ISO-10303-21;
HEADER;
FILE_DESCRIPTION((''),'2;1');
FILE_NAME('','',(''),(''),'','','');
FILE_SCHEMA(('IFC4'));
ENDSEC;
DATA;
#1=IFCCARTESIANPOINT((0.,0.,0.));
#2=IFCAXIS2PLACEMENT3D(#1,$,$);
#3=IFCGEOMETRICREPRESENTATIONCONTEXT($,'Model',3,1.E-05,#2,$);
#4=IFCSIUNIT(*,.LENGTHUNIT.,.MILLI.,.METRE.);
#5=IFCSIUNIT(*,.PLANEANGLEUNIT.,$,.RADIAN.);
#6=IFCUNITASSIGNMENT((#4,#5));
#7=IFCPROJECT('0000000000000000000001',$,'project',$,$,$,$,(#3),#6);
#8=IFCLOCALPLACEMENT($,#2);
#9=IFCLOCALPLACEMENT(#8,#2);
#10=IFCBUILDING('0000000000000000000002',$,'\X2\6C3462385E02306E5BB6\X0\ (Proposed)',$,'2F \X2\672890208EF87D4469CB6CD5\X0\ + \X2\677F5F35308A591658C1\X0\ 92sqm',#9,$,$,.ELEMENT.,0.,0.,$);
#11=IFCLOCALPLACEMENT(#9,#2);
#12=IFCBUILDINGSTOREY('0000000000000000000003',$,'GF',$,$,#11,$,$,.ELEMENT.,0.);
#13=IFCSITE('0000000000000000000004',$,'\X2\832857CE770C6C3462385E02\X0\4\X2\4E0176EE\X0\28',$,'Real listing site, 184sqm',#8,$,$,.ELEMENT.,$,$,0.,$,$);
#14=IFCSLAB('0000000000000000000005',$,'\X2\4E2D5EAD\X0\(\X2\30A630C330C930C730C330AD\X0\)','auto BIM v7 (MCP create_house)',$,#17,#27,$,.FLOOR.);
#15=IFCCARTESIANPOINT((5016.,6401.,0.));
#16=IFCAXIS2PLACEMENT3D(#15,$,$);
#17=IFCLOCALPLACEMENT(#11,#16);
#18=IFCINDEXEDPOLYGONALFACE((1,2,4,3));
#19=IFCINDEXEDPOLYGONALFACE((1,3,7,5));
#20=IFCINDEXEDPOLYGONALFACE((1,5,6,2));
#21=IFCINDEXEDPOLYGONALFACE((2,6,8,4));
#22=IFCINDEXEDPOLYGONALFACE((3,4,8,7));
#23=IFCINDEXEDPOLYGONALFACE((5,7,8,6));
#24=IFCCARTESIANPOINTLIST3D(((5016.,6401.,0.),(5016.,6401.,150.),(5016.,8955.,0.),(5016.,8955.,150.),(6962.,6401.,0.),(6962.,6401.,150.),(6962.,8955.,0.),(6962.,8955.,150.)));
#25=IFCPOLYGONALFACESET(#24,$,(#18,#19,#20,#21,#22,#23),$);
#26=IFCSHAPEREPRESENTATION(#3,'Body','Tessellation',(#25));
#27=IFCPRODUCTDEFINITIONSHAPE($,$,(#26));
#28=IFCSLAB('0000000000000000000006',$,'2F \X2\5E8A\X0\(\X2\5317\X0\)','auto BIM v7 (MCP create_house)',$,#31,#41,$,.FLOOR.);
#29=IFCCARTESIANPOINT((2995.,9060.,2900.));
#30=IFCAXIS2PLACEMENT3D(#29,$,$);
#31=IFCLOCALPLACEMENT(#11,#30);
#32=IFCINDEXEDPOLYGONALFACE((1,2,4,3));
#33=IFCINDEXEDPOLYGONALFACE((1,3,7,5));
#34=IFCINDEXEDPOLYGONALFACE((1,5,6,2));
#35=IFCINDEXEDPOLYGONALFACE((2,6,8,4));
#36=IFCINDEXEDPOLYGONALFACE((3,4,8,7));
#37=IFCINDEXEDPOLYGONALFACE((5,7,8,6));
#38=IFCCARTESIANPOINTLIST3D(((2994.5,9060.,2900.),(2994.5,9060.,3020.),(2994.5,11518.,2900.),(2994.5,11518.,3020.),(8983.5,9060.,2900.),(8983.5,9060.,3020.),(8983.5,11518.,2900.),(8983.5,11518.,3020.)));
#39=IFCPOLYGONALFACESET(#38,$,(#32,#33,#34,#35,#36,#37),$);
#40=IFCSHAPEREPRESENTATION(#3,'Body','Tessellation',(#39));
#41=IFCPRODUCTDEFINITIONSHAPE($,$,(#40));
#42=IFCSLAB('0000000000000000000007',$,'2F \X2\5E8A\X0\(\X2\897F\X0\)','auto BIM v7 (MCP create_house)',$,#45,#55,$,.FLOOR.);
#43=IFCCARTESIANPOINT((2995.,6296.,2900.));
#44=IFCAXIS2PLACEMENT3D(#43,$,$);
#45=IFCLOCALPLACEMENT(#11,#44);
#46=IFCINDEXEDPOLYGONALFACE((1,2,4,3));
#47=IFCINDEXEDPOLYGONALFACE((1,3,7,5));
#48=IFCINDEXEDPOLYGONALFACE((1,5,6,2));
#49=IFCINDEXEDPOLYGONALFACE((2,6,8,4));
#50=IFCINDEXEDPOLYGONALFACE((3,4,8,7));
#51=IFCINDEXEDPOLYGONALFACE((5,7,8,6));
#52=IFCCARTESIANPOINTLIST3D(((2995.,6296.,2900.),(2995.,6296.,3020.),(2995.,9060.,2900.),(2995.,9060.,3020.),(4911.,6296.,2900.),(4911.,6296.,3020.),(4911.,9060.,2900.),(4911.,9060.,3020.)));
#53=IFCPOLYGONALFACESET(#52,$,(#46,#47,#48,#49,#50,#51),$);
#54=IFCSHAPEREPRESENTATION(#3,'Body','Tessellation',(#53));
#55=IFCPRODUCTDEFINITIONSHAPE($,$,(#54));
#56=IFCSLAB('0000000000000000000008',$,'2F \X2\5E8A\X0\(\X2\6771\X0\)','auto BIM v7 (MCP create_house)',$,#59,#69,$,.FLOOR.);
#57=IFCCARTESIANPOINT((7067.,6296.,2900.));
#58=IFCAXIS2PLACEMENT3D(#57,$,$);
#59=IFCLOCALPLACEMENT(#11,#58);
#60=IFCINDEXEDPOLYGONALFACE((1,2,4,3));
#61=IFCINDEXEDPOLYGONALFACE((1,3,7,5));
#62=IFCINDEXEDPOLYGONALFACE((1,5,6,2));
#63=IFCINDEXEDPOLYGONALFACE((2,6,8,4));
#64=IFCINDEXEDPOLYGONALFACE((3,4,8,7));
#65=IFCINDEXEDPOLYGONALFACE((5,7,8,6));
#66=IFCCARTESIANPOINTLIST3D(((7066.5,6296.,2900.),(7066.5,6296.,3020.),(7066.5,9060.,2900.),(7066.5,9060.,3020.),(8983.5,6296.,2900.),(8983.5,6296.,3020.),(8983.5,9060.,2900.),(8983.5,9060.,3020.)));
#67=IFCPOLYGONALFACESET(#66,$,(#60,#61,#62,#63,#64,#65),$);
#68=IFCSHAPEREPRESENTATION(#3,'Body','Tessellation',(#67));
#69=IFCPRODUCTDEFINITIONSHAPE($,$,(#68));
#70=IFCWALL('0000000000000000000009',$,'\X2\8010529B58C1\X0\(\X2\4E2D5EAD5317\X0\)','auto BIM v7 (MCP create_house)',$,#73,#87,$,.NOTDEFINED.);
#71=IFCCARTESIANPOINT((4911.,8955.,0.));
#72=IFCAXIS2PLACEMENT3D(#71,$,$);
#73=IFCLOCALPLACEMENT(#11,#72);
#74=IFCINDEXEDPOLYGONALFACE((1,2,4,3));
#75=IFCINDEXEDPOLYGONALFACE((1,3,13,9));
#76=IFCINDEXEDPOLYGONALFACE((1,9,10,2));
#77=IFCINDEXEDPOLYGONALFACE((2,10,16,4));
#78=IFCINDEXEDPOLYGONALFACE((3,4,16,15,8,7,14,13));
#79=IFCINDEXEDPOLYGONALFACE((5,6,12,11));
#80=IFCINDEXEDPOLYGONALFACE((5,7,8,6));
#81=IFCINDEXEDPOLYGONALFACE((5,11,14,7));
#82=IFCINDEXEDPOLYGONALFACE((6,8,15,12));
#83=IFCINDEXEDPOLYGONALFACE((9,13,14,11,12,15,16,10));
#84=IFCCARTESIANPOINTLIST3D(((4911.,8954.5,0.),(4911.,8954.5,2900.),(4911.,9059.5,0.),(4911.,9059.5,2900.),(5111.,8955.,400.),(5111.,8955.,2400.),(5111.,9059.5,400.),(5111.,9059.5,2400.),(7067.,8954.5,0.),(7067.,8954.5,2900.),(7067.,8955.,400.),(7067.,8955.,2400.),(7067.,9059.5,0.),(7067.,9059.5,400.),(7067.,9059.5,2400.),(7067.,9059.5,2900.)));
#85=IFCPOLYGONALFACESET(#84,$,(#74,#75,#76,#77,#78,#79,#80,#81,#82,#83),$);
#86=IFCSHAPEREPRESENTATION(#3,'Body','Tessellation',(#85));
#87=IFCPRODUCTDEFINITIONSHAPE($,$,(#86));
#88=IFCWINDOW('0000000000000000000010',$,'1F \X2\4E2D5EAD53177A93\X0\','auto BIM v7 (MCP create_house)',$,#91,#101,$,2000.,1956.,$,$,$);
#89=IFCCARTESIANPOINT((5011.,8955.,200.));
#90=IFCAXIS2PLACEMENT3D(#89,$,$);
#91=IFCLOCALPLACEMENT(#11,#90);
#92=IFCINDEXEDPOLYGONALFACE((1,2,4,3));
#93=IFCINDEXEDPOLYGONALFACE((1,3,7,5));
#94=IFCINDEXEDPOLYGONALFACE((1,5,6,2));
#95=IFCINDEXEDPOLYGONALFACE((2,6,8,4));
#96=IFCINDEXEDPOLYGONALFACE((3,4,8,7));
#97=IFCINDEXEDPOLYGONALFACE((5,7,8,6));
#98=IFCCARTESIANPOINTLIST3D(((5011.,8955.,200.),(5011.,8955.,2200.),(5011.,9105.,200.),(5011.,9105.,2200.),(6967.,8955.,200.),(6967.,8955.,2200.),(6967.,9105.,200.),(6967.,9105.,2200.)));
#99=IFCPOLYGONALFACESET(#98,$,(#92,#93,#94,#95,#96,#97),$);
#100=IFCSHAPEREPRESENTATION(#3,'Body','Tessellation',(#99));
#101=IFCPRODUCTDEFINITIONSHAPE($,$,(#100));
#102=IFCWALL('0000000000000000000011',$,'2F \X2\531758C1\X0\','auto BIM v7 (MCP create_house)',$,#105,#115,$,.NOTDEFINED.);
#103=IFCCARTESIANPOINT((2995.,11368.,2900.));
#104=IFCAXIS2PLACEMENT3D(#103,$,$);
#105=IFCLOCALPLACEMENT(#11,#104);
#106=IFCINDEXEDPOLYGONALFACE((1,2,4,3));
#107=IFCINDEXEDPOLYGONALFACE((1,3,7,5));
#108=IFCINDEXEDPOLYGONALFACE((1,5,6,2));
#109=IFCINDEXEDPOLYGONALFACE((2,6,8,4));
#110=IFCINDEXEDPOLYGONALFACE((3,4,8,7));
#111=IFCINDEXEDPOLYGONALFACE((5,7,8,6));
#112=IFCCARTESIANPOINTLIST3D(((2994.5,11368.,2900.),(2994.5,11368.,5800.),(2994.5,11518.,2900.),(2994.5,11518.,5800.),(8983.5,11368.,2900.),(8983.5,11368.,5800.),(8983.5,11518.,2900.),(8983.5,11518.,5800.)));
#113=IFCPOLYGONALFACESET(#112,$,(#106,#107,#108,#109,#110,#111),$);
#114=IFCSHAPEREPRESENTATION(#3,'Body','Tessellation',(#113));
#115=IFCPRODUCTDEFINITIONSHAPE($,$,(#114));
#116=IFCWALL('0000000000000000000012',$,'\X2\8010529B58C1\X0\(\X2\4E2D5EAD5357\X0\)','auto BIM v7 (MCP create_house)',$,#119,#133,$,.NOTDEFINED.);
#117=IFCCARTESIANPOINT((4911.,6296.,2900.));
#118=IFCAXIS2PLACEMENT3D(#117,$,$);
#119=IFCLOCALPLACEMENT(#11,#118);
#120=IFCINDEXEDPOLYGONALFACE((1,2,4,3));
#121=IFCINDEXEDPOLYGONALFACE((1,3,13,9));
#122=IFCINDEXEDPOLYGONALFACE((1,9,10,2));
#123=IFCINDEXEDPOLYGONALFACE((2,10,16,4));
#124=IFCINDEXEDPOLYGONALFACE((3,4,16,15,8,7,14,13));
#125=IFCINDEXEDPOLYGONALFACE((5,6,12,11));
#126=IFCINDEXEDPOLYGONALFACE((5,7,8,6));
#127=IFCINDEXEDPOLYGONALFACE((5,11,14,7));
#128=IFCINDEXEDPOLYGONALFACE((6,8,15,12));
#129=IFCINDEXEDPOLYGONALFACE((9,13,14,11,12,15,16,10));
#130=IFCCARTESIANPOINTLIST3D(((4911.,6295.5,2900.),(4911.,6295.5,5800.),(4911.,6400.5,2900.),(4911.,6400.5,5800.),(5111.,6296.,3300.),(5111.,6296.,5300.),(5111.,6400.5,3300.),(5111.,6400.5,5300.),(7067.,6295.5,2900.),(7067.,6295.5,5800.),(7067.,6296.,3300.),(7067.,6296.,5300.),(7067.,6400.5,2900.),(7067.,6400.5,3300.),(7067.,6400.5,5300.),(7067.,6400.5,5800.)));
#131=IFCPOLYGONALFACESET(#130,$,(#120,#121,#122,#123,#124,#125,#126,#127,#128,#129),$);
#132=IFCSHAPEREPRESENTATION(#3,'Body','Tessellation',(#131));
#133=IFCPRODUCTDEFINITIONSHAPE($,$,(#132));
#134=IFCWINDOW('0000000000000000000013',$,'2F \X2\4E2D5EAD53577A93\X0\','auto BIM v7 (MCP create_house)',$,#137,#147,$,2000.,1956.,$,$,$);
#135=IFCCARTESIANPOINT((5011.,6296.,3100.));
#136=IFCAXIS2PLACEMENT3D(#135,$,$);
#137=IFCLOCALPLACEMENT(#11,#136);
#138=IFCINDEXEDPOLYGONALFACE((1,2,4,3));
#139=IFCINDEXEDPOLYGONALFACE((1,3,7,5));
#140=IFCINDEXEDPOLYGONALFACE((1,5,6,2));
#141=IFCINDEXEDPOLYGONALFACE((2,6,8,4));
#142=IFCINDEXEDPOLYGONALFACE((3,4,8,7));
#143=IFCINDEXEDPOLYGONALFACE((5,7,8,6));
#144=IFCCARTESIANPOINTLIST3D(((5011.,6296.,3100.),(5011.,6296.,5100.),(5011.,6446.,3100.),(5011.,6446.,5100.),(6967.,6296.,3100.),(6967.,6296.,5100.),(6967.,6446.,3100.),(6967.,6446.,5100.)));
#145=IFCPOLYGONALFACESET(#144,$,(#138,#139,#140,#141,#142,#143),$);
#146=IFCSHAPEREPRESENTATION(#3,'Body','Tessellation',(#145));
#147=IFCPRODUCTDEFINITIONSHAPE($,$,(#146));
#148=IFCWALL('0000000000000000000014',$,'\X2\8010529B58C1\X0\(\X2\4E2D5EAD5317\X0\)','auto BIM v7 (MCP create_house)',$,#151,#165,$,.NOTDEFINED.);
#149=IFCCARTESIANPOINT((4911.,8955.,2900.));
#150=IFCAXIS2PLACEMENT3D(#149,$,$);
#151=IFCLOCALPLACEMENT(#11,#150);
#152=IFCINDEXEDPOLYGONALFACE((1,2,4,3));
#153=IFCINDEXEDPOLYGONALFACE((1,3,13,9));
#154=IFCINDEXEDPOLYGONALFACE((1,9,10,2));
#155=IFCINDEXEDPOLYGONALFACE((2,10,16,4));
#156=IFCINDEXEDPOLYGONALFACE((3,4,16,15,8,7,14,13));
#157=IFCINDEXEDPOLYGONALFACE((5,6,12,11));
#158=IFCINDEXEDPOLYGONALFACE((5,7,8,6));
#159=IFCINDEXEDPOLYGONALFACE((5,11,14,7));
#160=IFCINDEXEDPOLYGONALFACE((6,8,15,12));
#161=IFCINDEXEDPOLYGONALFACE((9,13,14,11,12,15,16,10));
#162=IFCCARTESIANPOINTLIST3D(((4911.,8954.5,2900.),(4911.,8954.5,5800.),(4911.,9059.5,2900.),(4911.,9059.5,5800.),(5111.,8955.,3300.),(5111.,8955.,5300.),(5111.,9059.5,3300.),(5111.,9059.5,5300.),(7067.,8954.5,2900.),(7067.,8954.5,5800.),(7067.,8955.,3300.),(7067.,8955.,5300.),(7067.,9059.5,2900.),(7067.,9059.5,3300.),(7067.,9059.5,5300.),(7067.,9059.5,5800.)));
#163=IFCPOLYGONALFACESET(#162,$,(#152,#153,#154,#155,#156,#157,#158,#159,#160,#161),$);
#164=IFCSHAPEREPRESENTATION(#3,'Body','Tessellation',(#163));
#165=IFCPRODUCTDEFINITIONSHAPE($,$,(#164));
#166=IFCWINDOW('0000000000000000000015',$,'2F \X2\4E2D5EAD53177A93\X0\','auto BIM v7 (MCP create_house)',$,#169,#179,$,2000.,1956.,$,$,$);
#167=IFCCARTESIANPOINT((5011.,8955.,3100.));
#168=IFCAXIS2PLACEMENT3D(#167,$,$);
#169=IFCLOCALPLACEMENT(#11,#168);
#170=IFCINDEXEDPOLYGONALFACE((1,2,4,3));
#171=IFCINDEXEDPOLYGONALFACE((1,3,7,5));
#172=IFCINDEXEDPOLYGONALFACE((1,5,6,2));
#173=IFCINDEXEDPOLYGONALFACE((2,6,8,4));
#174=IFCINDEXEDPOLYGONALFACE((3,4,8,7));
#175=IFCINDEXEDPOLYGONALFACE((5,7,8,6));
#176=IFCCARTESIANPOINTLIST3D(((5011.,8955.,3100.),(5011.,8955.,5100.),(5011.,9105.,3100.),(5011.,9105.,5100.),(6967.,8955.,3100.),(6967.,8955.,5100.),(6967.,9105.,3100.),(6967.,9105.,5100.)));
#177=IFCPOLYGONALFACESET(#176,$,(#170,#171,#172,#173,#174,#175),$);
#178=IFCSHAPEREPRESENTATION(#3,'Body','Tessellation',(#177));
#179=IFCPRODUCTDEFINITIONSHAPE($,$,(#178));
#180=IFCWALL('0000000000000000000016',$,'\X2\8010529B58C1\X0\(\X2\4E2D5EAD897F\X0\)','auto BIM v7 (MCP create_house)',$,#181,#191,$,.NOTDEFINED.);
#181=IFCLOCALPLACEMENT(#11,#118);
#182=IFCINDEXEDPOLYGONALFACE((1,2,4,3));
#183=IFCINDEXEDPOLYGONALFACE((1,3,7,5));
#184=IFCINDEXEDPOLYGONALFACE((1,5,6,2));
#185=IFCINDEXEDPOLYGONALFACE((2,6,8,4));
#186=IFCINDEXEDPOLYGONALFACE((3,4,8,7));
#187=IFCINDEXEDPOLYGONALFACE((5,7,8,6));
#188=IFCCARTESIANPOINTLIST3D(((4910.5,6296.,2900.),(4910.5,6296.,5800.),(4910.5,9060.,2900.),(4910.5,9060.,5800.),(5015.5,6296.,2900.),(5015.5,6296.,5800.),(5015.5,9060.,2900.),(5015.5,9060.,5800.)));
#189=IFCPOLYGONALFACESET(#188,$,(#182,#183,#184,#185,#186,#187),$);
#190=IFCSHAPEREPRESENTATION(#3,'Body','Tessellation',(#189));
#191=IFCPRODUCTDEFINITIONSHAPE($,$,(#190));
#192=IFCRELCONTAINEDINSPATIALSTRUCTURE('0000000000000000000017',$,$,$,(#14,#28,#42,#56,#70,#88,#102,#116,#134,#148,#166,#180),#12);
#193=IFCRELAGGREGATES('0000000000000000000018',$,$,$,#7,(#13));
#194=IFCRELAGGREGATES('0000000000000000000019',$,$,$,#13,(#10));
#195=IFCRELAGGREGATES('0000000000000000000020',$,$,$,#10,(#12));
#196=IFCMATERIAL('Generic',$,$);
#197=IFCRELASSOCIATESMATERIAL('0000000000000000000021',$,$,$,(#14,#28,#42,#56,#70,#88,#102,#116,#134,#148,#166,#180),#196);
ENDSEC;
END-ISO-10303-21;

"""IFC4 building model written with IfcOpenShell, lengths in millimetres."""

from ifc_helpers import new_model, si_unit, frame, frame_2d, origin, place, context, project, spatial, rectangle, extrude, material, element, fill, save


model = new_model("IFC4")

# Units and contexts
model_context = context("Model", 3, precision=1e-05, world=origin())
ifc_project = project(units=[si_unit("LENGTHUNIT", "METRE", prefix="MILLI"), si_unit("PLANEANGLEUNIT", "RADIAN")], contexts=[model_context])

# Site, building, storey
site_placement = place(None, origin())
site = spatial("IfcSite", under=ifc_project, at=site_placement, Name="茨城県水戸市4丁目28", ObjectType="Real listing site, 184sqm", CompositionType="ELEMENT", RefElevation=0.0)
building_placement = place(site_placement, origin())
building = spatial("IfcBuilding", under=site, at=building_placement, Name="水戸市の家 (Proposed)", ObjectType="2F 木造軸組構法 + 板張り外壁 92sqm", CompositionType="ELEMENT", ElevationOfRefHeight=0.0, ElevationOfTerrain=0.0)
storey_placement = place(building_placement, origin())
storey = spatial("IfcBuildingStorey", under=building, at=storey_placement, Name="GF", CompositionType="ELEMENT", Elevation=0.0)

# Slabs
ifc_material = material(Name="Generic")
slab_1_placement = place(storey_placement, frame((5016.0, 6401.0, 0.0)))
element("IfcSlab", 1, at=slab_1_placement, inside=storey, material=ifc_material, Name="中庭(ウッドデッキ)", Description="auto BIM v7 (MCP create_house)", PredefinedType="FLOOR", context=model_context, shape_type="SweptSolid", body=[
    extrude(rectangle(XDim=1946.0, YDim=2554.0, at=frame_2d((973.0, 1277.0))), frame((5016.0, 6401.0, 0.0)), (0.0, 0.0, 1.0), 150.0),
])
slab_2_placement = place(storey_placement, frame((2995.0, 9060.0, 2900.0)))
element("IfcSlab", 2, at=slab_2_placement, inside=storey, material=ifc_material, Name="2F 床(北)", Description="auto BIM v7 (MCP create_house)", PredefinedType="FLOOR", context=model_context, shape_type="SweptSolid", body=[
    extrude(rectangle(XDim=5989.0, YDim=2458.0, at=frame_2d((2994.0, 1229.0))), frame((2995.0, 9060.0, 2900.0)), (0.0, 0.0, 1.0), 120.0),
])
slab_3_placement = place(storey_placement, frame((2995.0, 6296.0, 2900.0)))
element("IfcSlab", 3, at=slab_3_placement, inside=storey, material=ifc_material, Name="2F 床(西)", Description="auto BIM v7 (MCP create_house)", PredefinedType="FLOOR", context=model_context, shape_type="SweptSolid", body=[
    extrude(rectangle(XDim=1916.0, YDim=2764.0, at=frame_2d((958.0, 1382.0))), frame((2995.0, 6296.0, 2900.0)), (0.0, 0.0, 1.0), 120.0),
])
slab_4_placement = place(storey_placement, frame((7067.0, 6296.0, 2900.0)))
element("IfcSlab", 4, at=slab_4_placement, inside=storey, material=ifc_material, Name="2F 床(東)", Description="auto BIM v7 (MCP create_house)", PredefinedType="FLOOR", context=model_context, shape_type="SweptSolid", body=[
    extrude(rectangle(XDim=1917.0, YDim=2764.0, at=frame_2d((958.0, 1382.0))), frame((7067.0, 6296.0, 2900.0)), (0.0, 0.0, 1.0), 120.0),
])

# Wall, opening, window
wall_1_placement = place(storey_placement, frame((4911.0, 8955.0, 0.0)))
wall_1 = element("IfcWall", 5, at=wall_1_placement, inside=storey, material=ifc_material, Name="耐力壁(中庭北)", Description="auto BIM v7 (MCP create_house)", PredefinedType="NOTDEFINED", context=model_context, shape_type="SweptSolid", body=[
    extrude(rectangle(XDim=2156.0, YDim=105.0, at=frame_2d((1078.0, 52.0))), frame((4911.0, 8955.0, 0.0)), (0.0, 0.0, 1.0), 2900.0),
])
opening_1_placement = place(storey_placement, frame((5011.0, 8955.0, 200.0)))
opening_1 = element("IfcOpeningElement", 6, at=opening_1_placement, cuts=wall_1, PredefinedType="NOTDEFINED", context=model_context, shape_type="SweptSolid", body=[
    extrude(rectangle(XDim=1956.0, YDim=150.0, at=frame_2d((978.0, 75.0))), frame((5011.0, 8955.0, 200.0)), (0.0, 0.0, 1.0), 2000.0),
])
window_1_placement = place(storey_placement, frame((5011.0, 8955.0, 200.0)))
window_1 = element("IfcWindow", 7, at=window_1_placement, inside=storey, material=ifc_material, Name="1F 中庭北窓", Description="auto BIM v7 (MCP create_house)", OverallHeight=2000.0, OverallWidth=1956.0, context=model_context, shape_type="SweptSolid", body=[
    extrude(rectangle(XDim=1956.0, YDim=150.0, at=frame_2d((978.0, 75.0))), frame((5011.0, 8955.0, 200.0)), (0.0, 0.0, 1.0), 2000.0),
])
fill(opening_1, window_1)

# Wall
wall_2_placement = place(storey_placement, frame((2995.0, 11368.0, 2900.0)))
element("IfcWall", 8, at=wall_2_placement, inside=storey, material=ifc_material, Name="2F 北壁", Description="auto BIM v7 (MCP create_house)", PredefinedType="NOTDEFINED", context=model_context, shape_type="SweptSolid", body=[
    extrude(rectangle(XDim=5989.0, YDim=150.0, at=frame_2d((2994.0, 75.0))), frame((2995.0, 11368.0, 2900.0)), (0.0, 0.0, 1.0), 2900.0),
])

# Walls, openings, windows
wall_3_placement = place(storey_placement, frame((4911.0, 6296.0, 2900.0)))
wall_3 = element("IfcWall", 9, at=wall_3_placement, inside=storey, material=ifc_material, Name="耐力壁(中庭南)", Description="auto BIM v7 (MCP create_house)", PredefinedType="NOTDEFINED", context=model_context, shape_type="SweptSolid", body=[
    extrude(rectangle(XDim=2156.0, YDim=105.0, at=frame_2d((1078.0, 52.0))), frame((4911.0, 6296.0, 2900.0)), (0.0, 0.0, 1.0), 2900.0),
])
opening_2_placement = place(storey_placement, frame((5011.0, 6296.0, 3100.0)))
opening_2 = element("IfcOpeningElement", 10, at=opening_2_placement, cuts=wall_3, PredefinedType="NOTDEFINED", context=model_context, shape_type="SweptSolid", body=[
    extrude(rectangle(XDim=1956.0, YDim=150.0, at=frame_2d((978.0, 75.0))), frame((5011.0, 6296.0, 3100.0)), (0.0, 0.0, 1.0), 2000.0),
])
window_2_placement = place(storey_placement, frame((5011.0, 6296.0, 3100.0)))
window_2 = element("IfcWindow", 11, at=window_2_placement, inside=storey, material=ifc_material, Name="2F 中庭南窓", Description="auto BIM v7 (MCP create_house)", OverallHeight=2000.0, OverallWidth=1956.0, context=model_context, shape_type="SweptSolid", body=[
    extrude(rectangle(XDim=1956.0, YDim=150.0, at=frame_2d((978.0, 75.0))), frame((5011.0, 6296.0, 3100.0)), (0.0, 0.0, 1.0), 2000.0),
])
fill(opening_2, window_2)
wall_4_placement = place(storey_placement, frame((4911.0, 8955.0, 2900.0)))
wall_4 = element("IfcWall", 12, at=wall_4_placement, inside=storey, material=ifc_material, Name="耐力壁(中庭北)", Description="auto BIM v7 (MCP create_house)", PredefinedType="NOTDEFINED", context=model_context, shape_type="SweptSolid", body=[
    extrude(rectangle(XDim=2156.0, YDim=105.0, at=frame_2d((1078.0, 52.0))), frame((4911.0, 8955.0, 2900.0)), (0.0, 0.0, 1.0), 2900.0),
])
opening_3_placement = place(storey_placement, frame((5011.0, 8955.0, 3100.0)))
opening_3 = element("IfcOpeningElement", 13, at=opening_3_placement, cuts=wall_4, PredefinedType="NOTDEFINED", context=model_context, shape_type="SweptSolid", body=[
    extrude(rectangle(XDim=1956.0, YDim=150.0, at=frame_2d((978.0, 75.0))), frame((5011.0, 8955.0, 3100.0)), (0.0, 0.0, 1.0), 2000.0),
])
window_3_placement = place(storey_placement, frame((5011.0, 8955.0, 3100.0)))
window_3 = element("IfcWindow", 14, at=window_3_placement, inside=storey, material=ifc_material, Name="2F 中庭北窓", Description="auto BIM v7 (MCP create_house)", OverallHeight=2000.0, OverallWidth=1956.0, context=model_context, shape_type="SweptSolid", body=[
    extrude(rectangle(XDim=1956.0, YDim=150.0, at=frame_2d((978.0, 75.0))), frame((5011.0, 8955.0, 3100.0)), (0.0, 0.0, 1.0), 2000.0),
])
fill(opening_3, window_3)

# Wall
wall_5_placement = place(storey_placement, frame((4911.0, 6296.0, 2900.0)))
element("IfcWall", 15, at=wall_5_placement, inside=storey, material=ifc_material, Name="耐力壁(中庭西)", Description="auto BIM v7 (MCP create_house)", PredefinedType="NOTDEFINED", context=model_context, shape_type="SweptSolid", body=[
    extrude(rectangle(XDim=105.0, YDim=2764.0, at=frame_2d((52.0, 1382.0))), frame((4911.0, 6296.0, 2900.0)), (0.0, 0.0, 1.0), 2900.0),
])

save(model, "model.ifc")
